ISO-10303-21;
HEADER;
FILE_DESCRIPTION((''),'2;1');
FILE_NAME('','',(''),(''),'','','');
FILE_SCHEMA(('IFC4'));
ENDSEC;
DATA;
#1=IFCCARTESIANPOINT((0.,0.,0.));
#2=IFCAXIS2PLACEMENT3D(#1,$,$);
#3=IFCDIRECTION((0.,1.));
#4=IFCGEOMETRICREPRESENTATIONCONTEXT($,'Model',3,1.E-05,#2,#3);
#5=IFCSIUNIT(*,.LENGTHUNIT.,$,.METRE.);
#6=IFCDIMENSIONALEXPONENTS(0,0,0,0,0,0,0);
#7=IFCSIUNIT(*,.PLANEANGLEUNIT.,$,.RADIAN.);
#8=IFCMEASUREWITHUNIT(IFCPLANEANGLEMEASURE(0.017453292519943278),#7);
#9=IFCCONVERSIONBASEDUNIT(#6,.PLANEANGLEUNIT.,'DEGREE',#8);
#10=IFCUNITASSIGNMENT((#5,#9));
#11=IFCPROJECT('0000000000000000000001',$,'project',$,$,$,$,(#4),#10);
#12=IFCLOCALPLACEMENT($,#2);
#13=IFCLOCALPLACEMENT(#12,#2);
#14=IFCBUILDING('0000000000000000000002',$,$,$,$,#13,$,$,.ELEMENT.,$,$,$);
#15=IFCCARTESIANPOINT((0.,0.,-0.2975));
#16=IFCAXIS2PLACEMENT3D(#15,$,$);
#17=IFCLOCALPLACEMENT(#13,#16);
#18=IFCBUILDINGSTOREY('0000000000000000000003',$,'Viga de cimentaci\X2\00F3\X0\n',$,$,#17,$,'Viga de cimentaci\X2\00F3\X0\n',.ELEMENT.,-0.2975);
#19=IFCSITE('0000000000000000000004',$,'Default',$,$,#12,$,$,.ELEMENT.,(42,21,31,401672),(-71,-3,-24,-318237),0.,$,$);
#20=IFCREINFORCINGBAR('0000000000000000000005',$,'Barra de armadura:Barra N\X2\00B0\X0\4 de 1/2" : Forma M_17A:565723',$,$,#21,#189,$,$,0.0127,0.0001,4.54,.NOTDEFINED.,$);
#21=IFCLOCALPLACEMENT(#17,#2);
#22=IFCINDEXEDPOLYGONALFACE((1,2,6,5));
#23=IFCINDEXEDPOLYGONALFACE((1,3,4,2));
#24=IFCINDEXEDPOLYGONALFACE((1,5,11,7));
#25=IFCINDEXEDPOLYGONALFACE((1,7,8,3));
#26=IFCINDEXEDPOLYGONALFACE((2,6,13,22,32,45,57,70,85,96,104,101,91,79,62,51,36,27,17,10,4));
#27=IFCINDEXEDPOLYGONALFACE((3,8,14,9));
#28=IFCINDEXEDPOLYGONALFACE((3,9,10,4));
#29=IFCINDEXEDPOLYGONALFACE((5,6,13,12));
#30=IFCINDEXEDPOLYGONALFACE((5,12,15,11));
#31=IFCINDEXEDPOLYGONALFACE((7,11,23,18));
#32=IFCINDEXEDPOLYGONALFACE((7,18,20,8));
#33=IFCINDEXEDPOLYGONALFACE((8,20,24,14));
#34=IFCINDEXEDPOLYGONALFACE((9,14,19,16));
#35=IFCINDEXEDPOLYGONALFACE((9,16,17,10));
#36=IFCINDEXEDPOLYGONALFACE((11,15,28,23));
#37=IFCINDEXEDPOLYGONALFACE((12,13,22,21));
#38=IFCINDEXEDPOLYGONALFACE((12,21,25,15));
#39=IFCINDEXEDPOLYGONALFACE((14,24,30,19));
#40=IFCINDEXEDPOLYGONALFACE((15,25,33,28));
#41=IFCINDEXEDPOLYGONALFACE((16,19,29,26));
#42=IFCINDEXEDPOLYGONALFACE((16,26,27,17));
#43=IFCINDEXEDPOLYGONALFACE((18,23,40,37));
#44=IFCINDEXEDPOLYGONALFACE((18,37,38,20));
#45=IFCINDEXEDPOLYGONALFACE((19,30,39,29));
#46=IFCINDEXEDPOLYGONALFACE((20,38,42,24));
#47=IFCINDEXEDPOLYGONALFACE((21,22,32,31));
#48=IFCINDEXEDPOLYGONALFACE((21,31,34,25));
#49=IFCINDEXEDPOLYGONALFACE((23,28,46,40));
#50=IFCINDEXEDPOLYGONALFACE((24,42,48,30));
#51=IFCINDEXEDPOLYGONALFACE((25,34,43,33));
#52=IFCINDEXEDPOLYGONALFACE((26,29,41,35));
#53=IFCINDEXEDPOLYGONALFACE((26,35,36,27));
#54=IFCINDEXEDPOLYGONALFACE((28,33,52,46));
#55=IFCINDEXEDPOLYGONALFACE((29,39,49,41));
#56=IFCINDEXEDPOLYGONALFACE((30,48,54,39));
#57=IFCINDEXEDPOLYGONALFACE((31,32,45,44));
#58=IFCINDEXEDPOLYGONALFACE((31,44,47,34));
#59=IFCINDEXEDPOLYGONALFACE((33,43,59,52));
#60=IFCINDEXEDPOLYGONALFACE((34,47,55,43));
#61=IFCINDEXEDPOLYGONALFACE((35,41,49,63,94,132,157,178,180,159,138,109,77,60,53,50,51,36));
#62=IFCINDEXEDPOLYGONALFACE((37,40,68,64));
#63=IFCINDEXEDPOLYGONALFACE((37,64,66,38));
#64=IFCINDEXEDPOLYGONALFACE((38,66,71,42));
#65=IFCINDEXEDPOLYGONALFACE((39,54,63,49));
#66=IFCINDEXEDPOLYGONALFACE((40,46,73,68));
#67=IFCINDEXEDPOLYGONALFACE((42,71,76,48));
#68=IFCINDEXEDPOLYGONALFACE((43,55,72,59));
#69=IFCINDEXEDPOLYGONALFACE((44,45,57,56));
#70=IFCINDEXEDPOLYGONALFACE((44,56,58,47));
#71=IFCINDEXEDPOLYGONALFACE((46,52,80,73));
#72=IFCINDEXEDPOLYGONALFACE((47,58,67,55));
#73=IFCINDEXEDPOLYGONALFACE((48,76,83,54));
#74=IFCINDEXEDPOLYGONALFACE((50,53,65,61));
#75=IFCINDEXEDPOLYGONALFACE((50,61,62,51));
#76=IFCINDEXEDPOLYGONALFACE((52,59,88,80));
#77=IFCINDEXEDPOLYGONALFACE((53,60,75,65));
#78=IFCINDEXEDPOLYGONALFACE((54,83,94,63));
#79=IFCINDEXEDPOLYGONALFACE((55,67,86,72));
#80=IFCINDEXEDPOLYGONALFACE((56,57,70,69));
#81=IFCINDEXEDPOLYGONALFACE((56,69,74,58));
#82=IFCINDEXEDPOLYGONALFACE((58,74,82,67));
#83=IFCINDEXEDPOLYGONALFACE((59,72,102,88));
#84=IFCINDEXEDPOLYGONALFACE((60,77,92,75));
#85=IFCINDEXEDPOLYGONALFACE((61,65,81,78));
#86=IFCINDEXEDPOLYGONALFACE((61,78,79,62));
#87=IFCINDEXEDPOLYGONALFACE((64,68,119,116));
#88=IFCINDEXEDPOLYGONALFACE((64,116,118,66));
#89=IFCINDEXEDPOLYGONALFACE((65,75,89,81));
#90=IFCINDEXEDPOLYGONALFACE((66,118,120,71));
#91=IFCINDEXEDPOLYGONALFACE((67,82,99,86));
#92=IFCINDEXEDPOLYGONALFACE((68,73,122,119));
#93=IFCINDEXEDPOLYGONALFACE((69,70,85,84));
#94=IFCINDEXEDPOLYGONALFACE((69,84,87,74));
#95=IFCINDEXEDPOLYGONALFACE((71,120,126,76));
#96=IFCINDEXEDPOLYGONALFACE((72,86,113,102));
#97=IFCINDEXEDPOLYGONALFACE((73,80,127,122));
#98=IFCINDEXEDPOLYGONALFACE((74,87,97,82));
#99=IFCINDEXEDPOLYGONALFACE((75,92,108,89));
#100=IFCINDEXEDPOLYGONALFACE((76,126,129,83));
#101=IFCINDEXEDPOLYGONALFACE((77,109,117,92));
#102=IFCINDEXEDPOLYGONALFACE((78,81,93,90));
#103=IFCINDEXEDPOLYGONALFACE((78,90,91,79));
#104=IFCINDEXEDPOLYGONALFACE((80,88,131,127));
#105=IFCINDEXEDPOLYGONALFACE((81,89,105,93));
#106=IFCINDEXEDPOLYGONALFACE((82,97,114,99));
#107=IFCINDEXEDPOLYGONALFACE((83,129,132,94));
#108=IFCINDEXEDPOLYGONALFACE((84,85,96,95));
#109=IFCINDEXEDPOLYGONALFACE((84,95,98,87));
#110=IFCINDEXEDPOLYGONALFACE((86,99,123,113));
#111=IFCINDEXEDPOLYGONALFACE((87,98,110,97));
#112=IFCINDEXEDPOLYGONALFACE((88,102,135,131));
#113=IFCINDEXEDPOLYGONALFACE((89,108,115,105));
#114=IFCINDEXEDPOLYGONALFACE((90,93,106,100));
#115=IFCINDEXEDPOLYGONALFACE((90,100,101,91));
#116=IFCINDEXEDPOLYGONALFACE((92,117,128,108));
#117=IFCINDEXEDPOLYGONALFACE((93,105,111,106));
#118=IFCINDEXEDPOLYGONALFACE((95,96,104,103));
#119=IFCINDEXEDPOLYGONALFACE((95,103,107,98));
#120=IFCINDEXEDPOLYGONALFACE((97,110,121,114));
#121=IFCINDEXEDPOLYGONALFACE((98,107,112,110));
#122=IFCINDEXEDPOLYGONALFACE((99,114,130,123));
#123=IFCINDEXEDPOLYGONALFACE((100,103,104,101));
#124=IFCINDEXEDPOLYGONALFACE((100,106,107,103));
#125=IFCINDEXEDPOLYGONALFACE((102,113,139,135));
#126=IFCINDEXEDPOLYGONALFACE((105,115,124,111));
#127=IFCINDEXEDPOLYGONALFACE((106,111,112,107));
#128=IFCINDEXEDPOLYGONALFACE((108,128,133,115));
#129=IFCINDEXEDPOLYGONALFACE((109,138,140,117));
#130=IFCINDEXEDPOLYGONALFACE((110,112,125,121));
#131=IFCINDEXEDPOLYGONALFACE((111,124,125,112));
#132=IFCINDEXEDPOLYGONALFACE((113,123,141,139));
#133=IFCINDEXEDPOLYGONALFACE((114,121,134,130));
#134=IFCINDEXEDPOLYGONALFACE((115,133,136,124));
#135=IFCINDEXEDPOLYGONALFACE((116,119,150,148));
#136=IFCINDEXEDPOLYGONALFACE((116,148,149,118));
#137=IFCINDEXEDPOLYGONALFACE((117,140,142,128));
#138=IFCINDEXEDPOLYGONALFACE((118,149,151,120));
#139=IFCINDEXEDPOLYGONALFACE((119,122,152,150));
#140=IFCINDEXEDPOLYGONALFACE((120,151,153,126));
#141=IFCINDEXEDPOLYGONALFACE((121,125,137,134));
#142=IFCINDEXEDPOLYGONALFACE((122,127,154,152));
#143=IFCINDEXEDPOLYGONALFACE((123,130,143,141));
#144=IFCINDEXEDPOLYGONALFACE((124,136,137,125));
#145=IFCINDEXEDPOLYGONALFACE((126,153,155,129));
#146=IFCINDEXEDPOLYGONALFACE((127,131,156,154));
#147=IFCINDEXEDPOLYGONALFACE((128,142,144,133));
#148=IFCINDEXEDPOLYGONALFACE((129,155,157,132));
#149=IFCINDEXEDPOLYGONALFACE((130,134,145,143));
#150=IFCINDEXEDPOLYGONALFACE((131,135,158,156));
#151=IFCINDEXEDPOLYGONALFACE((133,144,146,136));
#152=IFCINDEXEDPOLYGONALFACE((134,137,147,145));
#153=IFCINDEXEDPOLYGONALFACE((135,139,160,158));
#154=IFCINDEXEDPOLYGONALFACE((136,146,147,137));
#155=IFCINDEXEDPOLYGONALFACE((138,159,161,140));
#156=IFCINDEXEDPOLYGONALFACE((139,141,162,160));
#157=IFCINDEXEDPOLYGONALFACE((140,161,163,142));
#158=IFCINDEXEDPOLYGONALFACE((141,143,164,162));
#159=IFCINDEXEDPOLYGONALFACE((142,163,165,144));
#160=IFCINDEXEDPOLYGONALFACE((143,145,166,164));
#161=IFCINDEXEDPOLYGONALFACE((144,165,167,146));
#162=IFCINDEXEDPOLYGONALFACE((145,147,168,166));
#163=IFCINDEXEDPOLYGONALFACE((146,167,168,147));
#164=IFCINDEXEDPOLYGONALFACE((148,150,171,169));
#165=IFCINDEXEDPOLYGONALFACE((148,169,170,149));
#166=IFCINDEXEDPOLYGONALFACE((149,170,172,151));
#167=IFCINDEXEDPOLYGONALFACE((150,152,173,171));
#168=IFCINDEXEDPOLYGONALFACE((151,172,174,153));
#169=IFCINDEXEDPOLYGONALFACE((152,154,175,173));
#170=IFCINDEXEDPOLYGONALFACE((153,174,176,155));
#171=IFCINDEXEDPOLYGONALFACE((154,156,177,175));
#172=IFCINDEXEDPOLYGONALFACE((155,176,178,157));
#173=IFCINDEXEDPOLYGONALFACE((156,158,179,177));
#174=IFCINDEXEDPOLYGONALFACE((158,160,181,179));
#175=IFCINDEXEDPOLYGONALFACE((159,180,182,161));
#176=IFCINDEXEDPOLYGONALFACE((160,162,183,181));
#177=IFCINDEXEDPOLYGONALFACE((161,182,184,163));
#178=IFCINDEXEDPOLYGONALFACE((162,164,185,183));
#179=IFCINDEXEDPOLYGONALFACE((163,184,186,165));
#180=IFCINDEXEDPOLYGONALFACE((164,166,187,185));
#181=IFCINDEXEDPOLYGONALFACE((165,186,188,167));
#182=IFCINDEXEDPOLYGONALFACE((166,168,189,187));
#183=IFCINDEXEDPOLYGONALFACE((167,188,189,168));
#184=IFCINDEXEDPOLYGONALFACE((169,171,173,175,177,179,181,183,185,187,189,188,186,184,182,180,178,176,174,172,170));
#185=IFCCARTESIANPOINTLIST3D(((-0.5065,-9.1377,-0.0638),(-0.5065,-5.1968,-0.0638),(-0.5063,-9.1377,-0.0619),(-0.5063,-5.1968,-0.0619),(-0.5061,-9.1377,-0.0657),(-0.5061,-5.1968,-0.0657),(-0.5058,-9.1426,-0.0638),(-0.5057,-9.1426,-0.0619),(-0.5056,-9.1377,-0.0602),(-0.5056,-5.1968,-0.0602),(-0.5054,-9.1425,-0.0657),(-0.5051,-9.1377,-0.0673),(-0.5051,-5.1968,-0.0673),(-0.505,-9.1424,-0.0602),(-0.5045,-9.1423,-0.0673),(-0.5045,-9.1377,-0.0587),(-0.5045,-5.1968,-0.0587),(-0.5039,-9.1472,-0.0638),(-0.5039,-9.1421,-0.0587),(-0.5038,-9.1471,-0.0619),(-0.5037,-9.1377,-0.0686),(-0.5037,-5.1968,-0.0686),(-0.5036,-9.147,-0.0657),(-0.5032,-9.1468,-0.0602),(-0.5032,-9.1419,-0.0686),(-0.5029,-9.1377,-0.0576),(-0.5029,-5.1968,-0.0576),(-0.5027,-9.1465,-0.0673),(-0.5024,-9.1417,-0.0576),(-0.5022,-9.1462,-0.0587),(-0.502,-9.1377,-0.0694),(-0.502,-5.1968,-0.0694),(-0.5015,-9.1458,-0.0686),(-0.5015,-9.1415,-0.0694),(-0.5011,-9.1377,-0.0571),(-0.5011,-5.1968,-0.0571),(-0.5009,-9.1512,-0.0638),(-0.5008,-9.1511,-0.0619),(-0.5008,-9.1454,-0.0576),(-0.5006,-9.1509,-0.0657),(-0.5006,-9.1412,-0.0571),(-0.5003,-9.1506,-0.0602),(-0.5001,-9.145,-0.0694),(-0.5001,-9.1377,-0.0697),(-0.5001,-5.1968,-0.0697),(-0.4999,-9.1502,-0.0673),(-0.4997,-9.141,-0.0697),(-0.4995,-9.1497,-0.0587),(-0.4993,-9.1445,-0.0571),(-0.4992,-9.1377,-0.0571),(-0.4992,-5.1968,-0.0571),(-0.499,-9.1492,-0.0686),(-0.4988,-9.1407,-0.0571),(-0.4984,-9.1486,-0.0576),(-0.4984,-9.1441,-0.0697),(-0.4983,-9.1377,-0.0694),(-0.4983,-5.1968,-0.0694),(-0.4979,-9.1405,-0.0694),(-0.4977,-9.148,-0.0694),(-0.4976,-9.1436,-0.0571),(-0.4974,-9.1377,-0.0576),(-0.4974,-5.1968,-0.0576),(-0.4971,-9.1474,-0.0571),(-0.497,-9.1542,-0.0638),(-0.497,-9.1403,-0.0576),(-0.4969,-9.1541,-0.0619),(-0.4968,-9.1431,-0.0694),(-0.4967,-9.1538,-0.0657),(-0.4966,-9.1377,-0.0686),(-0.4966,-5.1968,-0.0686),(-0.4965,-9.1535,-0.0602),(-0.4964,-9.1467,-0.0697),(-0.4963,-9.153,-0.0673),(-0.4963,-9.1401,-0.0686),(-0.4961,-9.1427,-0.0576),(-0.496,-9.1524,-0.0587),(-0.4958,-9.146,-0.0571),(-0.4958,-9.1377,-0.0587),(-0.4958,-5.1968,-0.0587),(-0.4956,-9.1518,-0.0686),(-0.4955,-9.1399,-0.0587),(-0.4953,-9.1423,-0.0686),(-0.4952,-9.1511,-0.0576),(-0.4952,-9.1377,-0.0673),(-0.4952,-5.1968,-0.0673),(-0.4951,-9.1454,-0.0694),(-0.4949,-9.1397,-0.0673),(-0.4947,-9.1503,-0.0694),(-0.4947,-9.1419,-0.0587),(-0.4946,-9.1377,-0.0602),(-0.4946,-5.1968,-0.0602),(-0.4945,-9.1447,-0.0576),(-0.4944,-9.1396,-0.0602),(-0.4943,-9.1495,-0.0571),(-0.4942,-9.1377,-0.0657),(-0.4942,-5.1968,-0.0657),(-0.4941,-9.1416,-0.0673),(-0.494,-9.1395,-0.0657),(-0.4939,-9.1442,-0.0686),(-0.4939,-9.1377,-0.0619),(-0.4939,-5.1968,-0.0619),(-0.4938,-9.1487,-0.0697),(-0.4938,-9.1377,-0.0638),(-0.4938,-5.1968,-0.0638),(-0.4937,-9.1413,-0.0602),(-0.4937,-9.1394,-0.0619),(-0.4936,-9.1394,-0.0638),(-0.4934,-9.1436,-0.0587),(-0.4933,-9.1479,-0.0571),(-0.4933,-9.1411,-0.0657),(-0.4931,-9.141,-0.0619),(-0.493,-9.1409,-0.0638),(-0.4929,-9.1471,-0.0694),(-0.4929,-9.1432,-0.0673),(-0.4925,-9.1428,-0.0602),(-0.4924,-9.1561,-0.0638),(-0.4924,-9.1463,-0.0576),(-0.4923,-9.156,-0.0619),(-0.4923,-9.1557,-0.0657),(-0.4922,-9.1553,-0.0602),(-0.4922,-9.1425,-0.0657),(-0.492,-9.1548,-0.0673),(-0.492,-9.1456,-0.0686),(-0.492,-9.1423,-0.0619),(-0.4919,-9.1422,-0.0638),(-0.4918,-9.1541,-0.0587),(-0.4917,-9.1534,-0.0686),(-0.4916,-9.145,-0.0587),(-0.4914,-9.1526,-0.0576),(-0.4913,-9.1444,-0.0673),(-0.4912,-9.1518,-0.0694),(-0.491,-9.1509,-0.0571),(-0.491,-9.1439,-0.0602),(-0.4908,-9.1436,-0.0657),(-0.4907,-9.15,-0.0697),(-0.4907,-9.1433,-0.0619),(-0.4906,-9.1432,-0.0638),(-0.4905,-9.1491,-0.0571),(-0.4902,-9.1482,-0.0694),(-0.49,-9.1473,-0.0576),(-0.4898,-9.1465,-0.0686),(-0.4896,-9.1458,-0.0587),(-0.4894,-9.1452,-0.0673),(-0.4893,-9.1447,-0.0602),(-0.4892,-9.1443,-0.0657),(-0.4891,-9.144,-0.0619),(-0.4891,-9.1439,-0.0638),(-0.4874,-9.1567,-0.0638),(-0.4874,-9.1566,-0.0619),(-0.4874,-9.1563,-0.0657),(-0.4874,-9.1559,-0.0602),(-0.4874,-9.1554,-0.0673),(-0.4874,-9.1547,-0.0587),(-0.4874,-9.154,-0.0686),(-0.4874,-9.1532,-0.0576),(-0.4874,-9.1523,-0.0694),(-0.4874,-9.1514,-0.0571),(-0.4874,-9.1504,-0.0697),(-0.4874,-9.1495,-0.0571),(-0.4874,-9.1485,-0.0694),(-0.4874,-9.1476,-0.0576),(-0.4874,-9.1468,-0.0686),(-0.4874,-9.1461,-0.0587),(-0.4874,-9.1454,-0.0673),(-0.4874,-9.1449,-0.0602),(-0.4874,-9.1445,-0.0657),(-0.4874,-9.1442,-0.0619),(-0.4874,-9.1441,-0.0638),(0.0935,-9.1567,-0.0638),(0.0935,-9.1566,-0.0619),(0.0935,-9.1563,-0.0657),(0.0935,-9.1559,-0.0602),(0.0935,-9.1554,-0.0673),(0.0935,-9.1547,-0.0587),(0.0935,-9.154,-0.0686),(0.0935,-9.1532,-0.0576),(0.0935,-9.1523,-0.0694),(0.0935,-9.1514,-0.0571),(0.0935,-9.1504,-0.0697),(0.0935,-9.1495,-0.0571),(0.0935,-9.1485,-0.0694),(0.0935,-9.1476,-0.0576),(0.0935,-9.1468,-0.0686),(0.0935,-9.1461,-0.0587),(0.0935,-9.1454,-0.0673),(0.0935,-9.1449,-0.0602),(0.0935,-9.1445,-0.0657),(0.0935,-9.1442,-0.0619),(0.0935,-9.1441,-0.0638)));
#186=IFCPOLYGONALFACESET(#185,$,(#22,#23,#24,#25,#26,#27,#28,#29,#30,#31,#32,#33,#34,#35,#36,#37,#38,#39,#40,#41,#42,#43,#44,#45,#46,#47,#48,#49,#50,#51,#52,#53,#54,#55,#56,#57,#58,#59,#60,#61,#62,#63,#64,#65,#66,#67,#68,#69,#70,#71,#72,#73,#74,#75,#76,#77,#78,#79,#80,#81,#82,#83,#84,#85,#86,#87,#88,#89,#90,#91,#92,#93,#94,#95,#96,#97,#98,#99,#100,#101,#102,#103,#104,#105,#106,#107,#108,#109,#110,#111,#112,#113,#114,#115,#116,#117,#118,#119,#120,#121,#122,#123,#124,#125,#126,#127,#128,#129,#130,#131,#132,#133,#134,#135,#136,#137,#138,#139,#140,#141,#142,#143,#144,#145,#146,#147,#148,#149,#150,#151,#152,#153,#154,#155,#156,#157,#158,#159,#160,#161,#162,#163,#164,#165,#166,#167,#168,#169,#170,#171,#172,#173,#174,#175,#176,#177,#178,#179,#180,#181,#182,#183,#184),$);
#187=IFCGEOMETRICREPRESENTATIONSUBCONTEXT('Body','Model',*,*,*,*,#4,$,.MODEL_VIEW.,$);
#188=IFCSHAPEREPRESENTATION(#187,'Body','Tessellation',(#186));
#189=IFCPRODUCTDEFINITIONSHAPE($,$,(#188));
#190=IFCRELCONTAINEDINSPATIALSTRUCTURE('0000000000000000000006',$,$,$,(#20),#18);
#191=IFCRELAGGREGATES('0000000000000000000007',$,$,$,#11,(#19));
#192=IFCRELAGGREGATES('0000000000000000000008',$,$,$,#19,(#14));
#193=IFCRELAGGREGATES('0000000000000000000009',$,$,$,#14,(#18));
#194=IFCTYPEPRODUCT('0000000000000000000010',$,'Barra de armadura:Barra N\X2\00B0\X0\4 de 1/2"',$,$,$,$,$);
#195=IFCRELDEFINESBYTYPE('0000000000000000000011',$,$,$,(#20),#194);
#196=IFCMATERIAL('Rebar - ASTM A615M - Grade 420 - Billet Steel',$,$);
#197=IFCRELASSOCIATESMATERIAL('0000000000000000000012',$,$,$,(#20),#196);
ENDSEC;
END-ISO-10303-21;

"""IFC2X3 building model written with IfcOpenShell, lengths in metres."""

from ifc_helpers import new_model, entity, si_unit, converted_unit, direction, frame, origin, place, context, subcontext, project, spatial, material, type_object, element, save


model = new_model("IFC2X3")

# Units and contexts
model_context = context("Model", 3, precision=1e-05, world=origin(), true_north=direction((0.0, 1.0)))
body_context = subcontext(model_context, "Body", "Model", "MODEL_VIEW")
ifc_project = project(units=[si_unit("LENGTHUNIT", "METRE"), converted_unit("PLANEANGLEUNIT", "DEGREE", entity("IfcPlaneAngleMeasure", 0.017453292519943278), si_unit("PLANEANGLEUNIT", "RADIAN"), dimensions=[0, 0, 0, 0, 0, 0, 0])], contexts=[model_context])

# Site, building, storey
site_placement = place(None, origin())
site = spatial("IfcSite", under=ifc_project, at=site_placement, Name="Default", CompositionType="ELEMENT", RefLatitude=(42, 21, 31, 401672), RefLongitude=(-71, -3, -24, -318237), RefElevation=0.0)
building_placement = place(site_placement, origin())
building = spatial("IfcBuilding", under=site, at=building_placement, CompositionType="ELEMENT")
storey_placement = place(building_placement, frame((0.0, 0.0, -0.2975)))
storey = spatial("IfcBuildingStorey", under=building, at=storey_placement, Name="Viga de cimentación", LongName="Viga de cimentación", CompositionType="ELEMENT", Elevation=-0.2975)

# Reinforcing bar
ifc_material = material(Name="Rebar - ASTM A615M - Grade 420 - Billet Steel")
type_product_1 = type_object("IfcTypeProduct", Name="Barra de armadura:Barra N°4 de 1/2\"")
reinforcing_bar_1_placement = place(storey_placement, origin())
element("IfcReinforcingBar", 1, at=reinforcing_bar_1_placement, inside=storey, type_object=type_product_1, material=ifc_material, Name="Barra de armadura:Barra N°4 de 1/2\" : Forma M_17A:565723", BarLength=4.54, BarRole="NOTDEFINED", CrossSectionArea=0.0001, NominalDiameter=0.0127, context=body_context, shape_type="AdvancedSweptSolid", body=[
    entity("IfcSweptDiskSolid", entity("IfcCompositeCurve", [entity("IfcCompositeCurveSegment", "CONTINUOUS", True, entity("IfcPolyline", [entity("IfcCartesianPoint", [-0.5001, -5.1968, -0.0633]), entity("IfcCartesianPoint", [-0.5001, -9.1377, -0.0634])])), entity("IfcCompositeCurveSegment", "CONTINUOUS", True, entity("IfcTrimmedCurve", entity("IfcCircle", entity("IfcAxis2Placement3D", entity("IfcCartesianPoint", [-0.4874, -9.1377, -0.0634]), entity("IfcDirection", [0.0, 0.0, 1.0]), entity("IfcDirection", [0.0, -1.0, 0.0])), 0.0127), [entity("IfcParameterValue", 270.0)], [entity("IfcParameterValue", 360.0)], True, "PARAMETER")), entity("IfcCompositeCurveSegment", "CONTINUOUS", True, entity("IfcPolyline", [entity("IfcCartesianPoint", [-0.4874, -9.1504, -0.0634]), entity("IfcCartesianPoint", [0.0935, -9.1504, -0.0634])]))], False), 0.0063, None, 0.0, 92.0),
])

save(model, "model.ifc")
